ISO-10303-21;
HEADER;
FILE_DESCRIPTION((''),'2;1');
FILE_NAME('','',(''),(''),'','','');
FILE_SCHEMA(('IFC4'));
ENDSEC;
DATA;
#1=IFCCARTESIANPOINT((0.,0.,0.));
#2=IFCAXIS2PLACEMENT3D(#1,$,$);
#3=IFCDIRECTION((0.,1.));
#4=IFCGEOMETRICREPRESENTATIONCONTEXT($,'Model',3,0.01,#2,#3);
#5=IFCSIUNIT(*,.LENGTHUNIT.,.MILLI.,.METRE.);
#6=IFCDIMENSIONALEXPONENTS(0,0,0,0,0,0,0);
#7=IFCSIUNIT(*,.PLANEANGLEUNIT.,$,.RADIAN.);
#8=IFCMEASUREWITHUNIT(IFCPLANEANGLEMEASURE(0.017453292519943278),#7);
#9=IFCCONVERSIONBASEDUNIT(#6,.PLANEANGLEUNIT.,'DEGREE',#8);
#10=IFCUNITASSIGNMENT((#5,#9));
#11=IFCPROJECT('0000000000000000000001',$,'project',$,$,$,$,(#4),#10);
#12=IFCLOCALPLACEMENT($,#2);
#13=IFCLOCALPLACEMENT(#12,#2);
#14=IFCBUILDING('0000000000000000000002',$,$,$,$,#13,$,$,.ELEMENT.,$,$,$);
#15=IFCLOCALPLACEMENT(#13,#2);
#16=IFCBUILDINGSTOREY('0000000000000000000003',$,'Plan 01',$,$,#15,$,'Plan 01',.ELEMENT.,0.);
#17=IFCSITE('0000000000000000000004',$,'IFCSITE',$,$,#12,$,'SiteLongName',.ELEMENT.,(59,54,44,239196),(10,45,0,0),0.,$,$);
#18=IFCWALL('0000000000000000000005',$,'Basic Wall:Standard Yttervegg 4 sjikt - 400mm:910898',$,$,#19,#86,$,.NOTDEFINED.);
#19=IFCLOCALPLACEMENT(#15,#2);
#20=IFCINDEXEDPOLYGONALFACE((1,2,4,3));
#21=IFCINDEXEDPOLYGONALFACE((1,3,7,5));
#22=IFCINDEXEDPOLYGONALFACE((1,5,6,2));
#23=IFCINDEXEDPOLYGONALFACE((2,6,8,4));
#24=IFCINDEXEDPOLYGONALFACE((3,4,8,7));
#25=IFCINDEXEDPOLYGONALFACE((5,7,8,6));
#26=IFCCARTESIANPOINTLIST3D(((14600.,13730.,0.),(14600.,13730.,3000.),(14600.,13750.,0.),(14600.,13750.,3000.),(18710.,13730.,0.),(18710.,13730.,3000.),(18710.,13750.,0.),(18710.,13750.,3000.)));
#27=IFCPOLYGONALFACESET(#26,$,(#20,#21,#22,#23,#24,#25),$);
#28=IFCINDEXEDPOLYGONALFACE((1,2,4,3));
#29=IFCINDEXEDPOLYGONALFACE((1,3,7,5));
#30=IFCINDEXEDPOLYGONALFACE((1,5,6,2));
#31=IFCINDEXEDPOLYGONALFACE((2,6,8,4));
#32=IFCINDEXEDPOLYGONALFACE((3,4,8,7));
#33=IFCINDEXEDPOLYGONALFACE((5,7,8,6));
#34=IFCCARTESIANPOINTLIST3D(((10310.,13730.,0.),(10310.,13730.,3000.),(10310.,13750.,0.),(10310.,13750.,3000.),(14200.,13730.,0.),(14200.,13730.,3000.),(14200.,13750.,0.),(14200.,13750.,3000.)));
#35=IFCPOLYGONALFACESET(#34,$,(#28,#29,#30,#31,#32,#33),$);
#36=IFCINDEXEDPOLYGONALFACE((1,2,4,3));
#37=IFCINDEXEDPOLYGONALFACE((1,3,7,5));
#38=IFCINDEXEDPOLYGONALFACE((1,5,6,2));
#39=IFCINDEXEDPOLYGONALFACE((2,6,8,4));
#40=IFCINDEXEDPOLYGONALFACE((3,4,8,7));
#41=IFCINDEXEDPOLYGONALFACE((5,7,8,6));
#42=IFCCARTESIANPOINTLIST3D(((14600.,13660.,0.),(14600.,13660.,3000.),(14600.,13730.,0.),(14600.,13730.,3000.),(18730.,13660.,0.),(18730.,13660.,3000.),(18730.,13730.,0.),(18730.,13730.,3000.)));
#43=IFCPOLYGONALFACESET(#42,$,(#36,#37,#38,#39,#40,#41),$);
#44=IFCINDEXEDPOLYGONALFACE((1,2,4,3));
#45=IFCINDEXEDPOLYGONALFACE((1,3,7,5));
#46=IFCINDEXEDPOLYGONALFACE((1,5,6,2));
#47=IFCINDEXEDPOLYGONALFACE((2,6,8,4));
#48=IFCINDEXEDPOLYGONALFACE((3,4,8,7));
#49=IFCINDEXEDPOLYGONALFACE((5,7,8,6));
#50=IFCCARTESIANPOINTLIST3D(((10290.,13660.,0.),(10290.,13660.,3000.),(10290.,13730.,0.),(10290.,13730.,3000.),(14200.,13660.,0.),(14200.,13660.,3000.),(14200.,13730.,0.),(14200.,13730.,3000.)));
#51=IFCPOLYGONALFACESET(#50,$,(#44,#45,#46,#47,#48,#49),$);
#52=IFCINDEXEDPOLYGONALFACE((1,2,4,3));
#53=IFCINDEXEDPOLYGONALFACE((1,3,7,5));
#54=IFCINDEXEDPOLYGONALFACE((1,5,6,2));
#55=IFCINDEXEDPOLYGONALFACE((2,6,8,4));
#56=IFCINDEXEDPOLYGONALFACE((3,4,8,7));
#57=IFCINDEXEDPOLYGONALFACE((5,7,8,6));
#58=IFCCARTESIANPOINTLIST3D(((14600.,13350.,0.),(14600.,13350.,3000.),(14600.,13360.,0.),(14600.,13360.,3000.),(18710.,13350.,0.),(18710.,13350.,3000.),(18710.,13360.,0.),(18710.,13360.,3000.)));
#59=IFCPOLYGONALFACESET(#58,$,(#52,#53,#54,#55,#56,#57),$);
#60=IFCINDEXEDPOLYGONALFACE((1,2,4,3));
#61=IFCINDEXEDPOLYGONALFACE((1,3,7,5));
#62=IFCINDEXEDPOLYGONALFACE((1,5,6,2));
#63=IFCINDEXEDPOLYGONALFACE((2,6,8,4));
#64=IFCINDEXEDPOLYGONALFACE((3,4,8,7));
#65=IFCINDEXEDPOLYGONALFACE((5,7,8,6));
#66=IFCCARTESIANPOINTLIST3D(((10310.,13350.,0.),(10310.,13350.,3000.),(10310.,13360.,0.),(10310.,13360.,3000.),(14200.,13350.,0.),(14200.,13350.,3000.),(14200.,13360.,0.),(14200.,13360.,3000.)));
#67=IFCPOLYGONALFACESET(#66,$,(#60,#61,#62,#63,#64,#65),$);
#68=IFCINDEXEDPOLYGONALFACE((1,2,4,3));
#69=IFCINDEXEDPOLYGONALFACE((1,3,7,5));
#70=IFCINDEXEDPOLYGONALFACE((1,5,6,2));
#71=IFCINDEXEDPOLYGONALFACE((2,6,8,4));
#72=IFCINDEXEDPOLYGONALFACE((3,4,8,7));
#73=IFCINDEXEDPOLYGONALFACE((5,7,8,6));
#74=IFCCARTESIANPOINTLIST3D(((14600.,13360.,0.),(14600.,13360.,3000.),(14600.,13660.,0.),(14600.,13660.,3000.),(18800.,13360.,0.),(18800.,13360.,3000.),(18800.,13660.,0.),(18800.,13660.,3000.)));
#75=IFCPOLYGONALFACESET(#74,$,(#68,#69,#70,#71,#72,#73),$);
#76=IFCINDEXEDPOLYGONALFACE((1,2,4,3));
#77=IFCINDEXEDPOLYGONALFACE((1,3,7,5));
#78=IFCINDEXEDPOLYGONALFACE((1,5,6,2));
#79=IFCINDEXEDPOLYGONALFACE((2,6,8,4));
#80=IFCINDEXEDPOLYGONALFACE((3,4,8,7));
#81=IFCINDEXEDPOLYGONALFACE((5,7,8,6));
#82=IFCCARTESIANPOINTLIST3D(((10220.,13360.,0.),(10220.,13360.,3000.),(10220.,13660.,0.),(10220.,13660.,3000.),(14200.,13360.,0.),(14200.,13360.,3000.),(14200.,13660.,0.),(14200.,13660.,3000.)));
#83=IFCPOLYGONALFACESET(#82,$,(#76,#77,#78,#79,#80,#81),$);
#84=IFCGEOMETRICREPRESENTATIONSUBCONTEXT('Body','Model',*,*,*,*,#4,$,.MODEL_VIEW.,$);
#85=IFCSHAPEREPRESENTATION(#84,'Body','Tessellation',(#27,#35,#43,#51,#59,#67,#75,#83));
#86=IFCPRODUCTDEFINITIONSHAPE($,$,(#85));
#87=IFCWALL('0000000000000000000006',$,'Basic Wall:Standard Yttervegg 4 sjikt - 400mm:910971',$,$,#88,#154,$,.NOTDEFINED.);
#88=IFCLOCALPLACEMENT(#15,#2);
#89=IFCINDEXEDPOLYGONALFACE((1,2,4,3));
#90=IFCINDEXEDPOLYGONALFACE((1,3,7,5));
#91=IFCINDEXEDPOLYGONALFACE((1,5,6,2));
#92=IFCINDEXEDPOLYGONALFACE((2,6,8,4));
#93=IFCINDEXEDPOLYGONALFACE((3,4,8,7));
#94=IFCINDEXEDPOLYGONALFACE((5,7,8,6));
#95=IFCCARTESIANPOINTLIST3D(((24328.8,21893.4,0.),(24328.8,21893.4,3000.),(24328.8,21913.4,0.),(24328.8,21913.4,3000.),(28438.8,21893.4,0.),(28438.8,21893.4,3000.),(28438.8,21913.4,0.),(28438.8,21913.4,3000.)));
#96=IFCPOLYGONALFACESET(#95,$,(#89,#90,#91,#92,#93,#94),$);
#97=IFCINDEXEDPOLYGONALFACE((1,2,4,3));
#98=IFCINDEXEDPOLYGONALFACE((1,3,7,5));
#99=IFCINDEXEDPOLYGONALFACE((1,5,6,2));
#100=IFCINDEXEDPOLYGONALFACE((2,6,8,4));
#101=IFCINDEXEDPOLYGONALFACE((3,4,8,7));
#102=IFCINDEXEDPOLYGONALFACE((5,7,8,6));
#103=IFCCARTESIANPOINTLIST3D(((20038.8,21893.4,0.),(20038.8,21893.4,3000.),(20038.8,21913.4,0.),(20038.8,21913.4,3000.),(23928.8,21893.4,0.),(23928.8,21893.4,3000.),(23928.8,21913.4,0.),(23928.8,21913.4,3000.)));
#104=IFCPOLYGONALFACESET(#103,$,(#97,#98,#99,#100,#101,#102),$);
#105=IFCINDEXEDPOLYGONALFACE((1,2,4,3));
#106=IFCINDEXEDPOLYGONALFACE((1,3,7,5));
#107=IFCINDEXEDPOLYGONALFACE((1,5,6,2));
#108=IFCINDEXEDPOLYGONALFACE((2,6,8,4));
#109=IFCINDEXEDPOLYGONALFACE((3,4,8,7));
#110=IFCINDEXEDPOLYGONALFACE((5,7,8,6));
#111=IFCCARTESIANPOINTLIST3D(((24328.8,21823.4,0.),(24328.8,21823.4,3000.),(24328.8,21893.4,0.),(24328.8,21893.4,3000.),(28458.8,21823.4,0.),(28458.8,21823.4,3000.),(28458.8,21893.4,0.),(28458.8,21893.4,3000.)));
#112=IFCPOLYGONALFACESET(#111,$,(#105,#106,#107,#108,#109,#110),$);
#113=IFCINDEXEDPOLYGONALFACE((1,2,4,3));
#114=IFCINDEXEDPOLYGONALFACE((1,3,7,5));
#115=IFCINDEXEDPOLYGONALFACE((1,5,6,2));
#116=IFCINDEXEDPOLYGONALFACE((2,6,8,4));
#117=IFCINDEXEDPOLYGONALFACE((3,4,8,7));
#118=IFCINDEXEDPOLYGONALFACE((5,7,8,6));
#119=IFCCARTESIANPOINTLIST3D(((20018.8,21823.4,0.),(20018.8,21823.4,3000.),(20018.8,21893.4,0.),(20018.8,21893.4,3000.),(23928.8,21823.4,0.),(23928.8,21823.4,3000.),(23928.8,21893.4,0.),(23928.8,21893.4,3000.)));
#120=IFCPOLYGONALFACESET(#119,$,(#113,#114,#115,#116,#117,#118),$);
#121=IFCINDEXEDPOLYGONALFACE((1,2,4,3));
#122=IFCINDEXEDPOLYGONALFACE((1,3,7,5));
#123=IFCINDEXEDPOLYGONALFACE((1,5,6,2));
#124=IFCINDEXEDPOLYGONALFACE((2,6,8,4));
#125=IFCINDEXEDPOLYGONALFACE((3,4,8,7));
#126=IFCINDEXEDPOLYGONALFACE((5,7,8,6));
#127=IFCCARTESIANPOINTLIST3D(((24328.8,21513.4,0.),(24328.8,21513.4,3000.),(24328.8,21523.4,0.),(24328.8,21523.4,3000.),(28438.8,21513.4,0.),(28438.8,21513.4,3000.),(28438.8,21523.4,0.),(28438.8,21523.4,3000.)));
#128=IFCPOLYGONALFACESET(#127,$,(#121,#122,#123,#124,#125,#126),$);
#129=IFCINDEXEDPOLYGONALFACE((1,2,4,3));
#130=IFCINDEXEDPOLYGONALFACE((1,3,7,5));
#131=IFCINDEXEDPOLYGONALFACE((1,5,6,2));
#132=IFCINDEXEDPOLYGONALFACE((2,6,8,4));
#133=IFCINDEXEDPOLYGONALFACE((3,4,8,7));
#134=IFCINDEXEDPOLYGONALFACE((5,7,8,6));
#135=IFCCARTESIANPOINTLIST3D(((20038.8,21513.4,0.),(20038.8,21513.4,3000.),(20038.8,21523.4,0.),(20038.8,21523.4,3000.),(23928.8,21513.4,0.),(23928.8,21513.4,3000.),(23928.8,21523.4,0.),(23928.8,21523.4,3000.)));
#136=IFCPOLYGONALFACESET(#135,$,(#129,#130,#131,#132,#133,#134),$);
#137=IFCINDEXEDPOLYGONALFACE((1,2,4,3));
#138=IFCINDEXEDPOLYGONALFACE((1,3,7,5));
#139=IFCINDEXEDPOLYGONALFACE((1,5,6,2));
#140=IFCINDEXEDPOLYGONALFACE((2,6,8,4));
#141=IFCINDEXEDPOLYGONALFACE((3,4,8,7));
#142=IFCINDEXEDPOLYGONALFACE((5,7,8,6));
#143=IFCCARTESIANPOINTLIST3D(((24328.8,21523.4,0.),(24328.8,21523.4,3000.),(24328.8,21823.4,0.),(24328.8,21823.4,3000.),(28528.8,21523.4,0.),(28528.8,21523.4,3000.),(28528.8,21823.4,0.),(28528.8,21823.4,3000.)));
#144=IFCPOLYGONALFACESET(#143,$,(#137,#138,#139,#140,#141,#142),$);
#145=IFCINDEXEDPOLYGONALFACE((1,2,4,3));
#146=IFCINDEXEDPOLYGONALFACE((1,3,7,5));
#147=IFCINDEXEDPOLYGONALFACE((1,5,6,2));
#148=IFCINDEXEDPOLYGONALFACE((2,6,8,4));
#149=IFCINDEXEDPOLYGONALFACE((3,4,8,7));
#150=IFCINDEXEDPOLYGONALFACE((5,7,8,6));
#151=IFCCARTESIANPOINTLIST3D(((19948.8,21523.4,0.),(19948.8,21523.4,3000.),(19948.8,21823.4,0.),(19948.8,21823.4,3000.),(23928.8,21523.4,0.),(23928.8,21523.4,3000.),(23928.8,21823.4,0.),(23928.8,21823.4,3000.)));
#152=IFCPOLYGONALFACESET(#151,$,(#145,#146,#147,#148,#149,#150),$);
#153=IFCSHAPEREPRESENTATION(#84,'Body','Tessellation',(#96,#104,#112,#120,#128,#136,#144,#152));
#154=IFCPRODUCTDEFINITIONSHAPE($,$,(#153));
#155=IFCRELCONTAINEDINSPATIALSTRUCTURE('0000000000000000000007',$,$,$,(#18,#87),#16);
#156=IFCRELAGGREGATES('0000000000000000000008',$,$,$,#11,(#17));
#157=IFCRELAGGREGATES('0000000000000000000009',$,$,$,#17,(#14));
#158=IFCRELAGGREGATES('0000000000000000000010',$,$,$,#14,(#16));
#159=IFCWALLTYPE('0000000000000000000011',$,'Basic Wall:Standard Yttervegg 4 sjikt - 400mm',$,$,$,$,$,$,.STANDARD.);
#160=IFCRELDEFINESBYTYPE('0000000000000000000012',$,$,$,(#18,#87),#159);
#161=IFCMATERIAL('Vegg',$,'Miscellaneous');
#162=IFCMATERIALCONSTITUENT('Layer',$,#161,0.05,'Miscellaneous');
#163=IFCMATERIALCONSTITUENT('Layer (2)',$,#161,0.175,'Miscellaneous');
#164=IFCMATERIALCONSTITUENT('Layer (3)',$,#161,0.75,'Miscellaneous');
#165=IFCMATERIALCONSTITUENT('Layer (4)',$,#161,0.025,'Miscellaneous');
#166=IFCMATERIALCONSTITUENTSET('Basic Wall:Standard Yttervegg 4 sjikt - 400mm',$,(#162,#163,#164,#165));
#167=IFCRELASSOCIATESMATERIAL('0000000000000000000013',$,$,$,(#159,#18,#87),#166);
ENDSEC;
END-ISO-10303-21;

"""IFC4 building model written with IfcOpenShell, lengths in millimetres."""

from ifc_helpers import new_model, entity, si_unit, converted_unit, direction, frame, origin, place, context, subcontext, project, spatial, indexed_curve, outline, extrude, material, constituent, constituent_set, type_object, element, save


model = new_model("IFC4")

# Units and contexts
model_context = context("Model", 3, precision=0.01, world=origin(), true_north=direction((0.0, 1.0)))
body_context = subcontext(model_context, "Body", "Model", "MODEL_VIEW")
ifc_project = project(units=[si_unit("LENGTHUNIT", "METRE", prefix="MILLI"), converted_unit("PLANEANGLEUNIT", "DEGREE", entity("IfcPlaneAngleMeasure", 0.017453292519943278), si_unit("PLANEANGLEUNIT", "RADIAN"), dimensions=[0, 0, 0, 0, 0, 0, 0])], contexts=[model_context])

# Site, building, storey
site_placement = place(None, origin())
site = spatial("IfcSite", under=ifc_project, at=site_placement, Name="IFCSITE", LongName="SiteLongName", CompositionType="ELEMENT", RefLatitude=(59, 54, 44, 239196), RefLongitude=(10, 45, 0, 0), RefElevation=0.0)
building_placement = place(site_placement, origin())
building = spatial("IfcBuilding", under=site, at=building_placement, CompositionType="ELEMENT")
storey_placement = place(building_placement, origin())
storey = spatial("IfcBuildingStorey", under=building, at=storey_placement, Name="Plan 01", LongName="Plan 01", CompositionType="ELEMENT", Elevation=0.0)

# Walls
ifc_material_1 = material(Name="Vegg", Category="Miscellaneous")
ifc_constituent_1 = constituent(ifc_material_1, Name="Layer", Category="Miscellaneous", fraction=0.05)
ifc_constituent_2 = constituent(ifc_material_1, Name="Layer (2)", Category="Miscellaneous", fraction=0.175)
ifc_constituent_3 = constituent(ifc_material_1, Name="Layer (3)", Category="Miscellaneous", fraction=0.75)
ifc_constituent_4 = constituent(ifc_material_1, Name="Layer (4)", Category="Miscellaneous", fraction=0.025)
ifc_constituent_set_1 = constituent_set(constituents=[ifc_constituent_1, ifc_constituent_2, ifc_constituent_3, ifc_constituent_4], Name="Basic Wall:Standard Yttervegg 4 sjikt - 400mm")
wall_type = type_object("IfcWallType", Name="Basic Wall:Standard Yttervegg 4 sjikt - 400mm", PredefinedType="STANDARD", material=ifc_constituent_set_1)
wall_1_placement = place(storey_placement, frame((10310.0, 13550.0, 0.0)))
element("IfcWall", 1, at=wall_1_placement, inside=storey, type_object=wall_type, material=ifc_constituent_set_1, Name="Basic Wall:Standard Yttervegg 4 sjikt - 400mm:910898", PredefinedType="NOTDEFINED", context=body_context, shape_type="SweptSolid", body=[
    extrude(outline(indexed_curve([(-10.0, -2055.0), (10.0, -2055.0), (10.0, 2055.0), (-10.0, 2055.0), (-10.0, -2055.0)], self_intersect=False)), frame((6345.0, 190.0, 0.0), z_axis=(0.0, 0.0, 1.0), x_axis=(0.0, -1.0, 0.0)), (0.0, 0.0, 1.0), 3000.0),
    extrude(outline(indexed_curve([(-10.0, -1945.0), (10.0, -1945.0), (10.0, 1945.0), (-10.0, 1945.0), (-10.0, -1945.0)], self_intersect=False)), frame((1945.0, 190.0, 0.0), z_axis=(0.0, 0.0, 1.0), x_axis=(0.0, -1.0, 0.0)), (0.0, 0.0, 1.0), 3000.0),
    extrude(outline(indexed_curve([(-2065.0, -35.0), (2065.0, -35.0), (2065.0, 35.0), (-2065.0, 35.0), (-2065.0, -35.0)], self_intersect=False)), frame((6355.0, 145.0, 0.0), z_axis=(0.0, 0.0, 1.0), x_axis=(-1.0, 0.0, 0.0)), (0.0, 0.0, 1.0), 3000.0),
    extrude(outline(indexed_curve([(-1955.0, -35.0), (1955.0, -35.0), (1955.0, 35.0), (-1955.0, 35.0), (-1955.0, -35.0)], self_intersect=False)), frame((1935.0, 145.0, 0.0)), (0.0, 0.0, 1.0), 3000.0),
    extrude(outline(indexed_curve([(-5.0, -2055.0), (5.0, -2055.0), (5.0, 2055.0), (-5.0, 2055.0), (-5.0, -2055.0)], self_intersect=False)), frame((6345.0, -195.0, 0.0), z_axis=(0.0, 0.0, 1.0), x_axis=(0.0, 1.0, 0.0)), (0.0, 0.0, 1.0), 3000.0),
    extrude(outline(indexed_curve([(-5.0, -1945.0), (5.0, -1945.0), (5.0, 1945.0), (-5.0, 1945.0), (-5.0, -1945.0)], self_intersect=False)), frame((1945.0, -195.0, 0.0), z_axis=(0.0, 0.0, 1.0), x_axis=(0.0, 1.0, 0.0)), (0.0, 0.0, 1.0), 3000.0),
    extrude(outline(indexed_curve([(-2100.0, -150.0), (2100.0, -150.0), (2100.0, 150.0), (-2100.0, 150.0), (-2100.0, -150.0)], self_intersect=False)), frame((6390.0, -40.0, 0.0), z_axis=(0.0, 0.0, 1.0), x_axis=(-1.0, 0.0, 0.0)), (0.0, 0.0, 1.0), 3000.0),
    extrude(outline(indexed_curve([(-1990.0, -150.0), (1990.0, -150.0), (1990.0, 150.0), (-1990.0, 150.0), (-1990.0, -150.0)], self_intersect=False)), frame((1900.0, -40.0, 0.0)), (0.0, 0.0, 1.0), 3000.0),
])
wall_2_placement = place(storey_placement, frame((20038.8, 21713.4, 0.0)))
element("IfcWall", 2, at=wall_2_placement, inside=storey, type_object=wall_type, material=ifc_constituent_set_1, Name="Basic Wall:Standard Yttervegg 4 sjikt - 400mm:910971", PredefinedType="NOTDEFINED", context=body_context, shape_type="SweptSolid", body=[
    extrude(outline(indexed_curve([(-10.0, -2055.0), (10.0, -2055.0), (10.0, 2055.0), (-10.0, 2055.0), (-10.0, -2055.0)], self_intersect=False)), frame((6345.0, 190.0, 0.0), z_axis=(0.0, 0.0, 1.0), x_axis=(0.0, -1.0, 0.0)), (0.0, 0.0, 1.0), 3000.0),
    extrude(outline(indexed_curve([(-10.0, -1945.0), (10.0, -1945.0), (10.0, 1945.0), (-10.0, 1945.0), (-10.0, -1945.0)], self_intersect=False)), frame((1945.0, 190.0, 0.0), z_axis=(0.0, 0.0, 1.0), x_axis=(0.0, -1.0, 0.0)), (0.0, 0.0, 1.0), 3000.0),
    extrude(outline(indexed_curve([(-2065.0, -35.0), (2065.0, -35.0), (2065.0, 35.0), (-2065.0, 35.0), (-2065.0, -35.0)], self_intersect=False)), frame((6355.0, 145.0, 0.0), z_axis=(0.0, 0.0, 1.0), x_axis=(-1.0, 0.0, 0.0)), (0.0, 0.0, 1.0), 3000.0),
    extrude(outline(indexed_curve([(-1955.0, -35.0), (1955.0, -35.0), (1955.0, 35.0), (-1955.0, 35.0), (-1955.0, -35.0)], self_intersect=False)), frame((1935.0, 145.0, 0.0)), (0.0, 0.0, 1.0), 3000.0),
    extrude(outline(indexed_curve([(-5.0, -2055.0), (5.0, -2055.0), (5.0, 2055.0), (-5.0, 2055.0), (-5.0, -2055.0)], self_intersect=False)), frame((6345.0, -195.0, 0.0), z_axis=(0.0, 0.0, 1.0), x_axis=(0.0, 1.0, 0.0)), (0.0, 0.0, 1.0), 3000.0),
    extrude(outline(indexed_curve([(-5.0, -1945.0), (5.0, -1945.0), (5.0, 1945.0), (-5.0, 1945.0), (-5.0, -1945.0)], self_intersect=False)), frame((1945.0, -195.0, 0.0), z_axis=(0.0, 0.0, 1.0), x_axis=(0.0, 1.0, 0.0)), (0.0, 0.0, 1.0), 3000.0),
    extrude(outline(indexed_curve([(-2100.0, -150.0), (2100.0, -150.0), (2100.0, 150.0), (-2100.0, 150.0), (-2100.0, -150.0)], self_intersect=False)), frame((6390.0, -40.0, 0.0), z_axis=(0.0, 0.0, 1.0), x_axis=(-1.0, 0.0, 0.0)), (0.0, 0.0, 1.0), 3000.0),
    extrude(outline(indexed_curve([(-1990.0, -150.0), (1990.0, -150.0), (1990.0, 150.0), (-1990.0, 150.0), (-1990.0, -150.0)], self_intersect=False)), frame((1900.0, -40.0, 0.0)), (0.0, 0.0, 1.0), 3000.0),
])

save(model, "model.ifc")
